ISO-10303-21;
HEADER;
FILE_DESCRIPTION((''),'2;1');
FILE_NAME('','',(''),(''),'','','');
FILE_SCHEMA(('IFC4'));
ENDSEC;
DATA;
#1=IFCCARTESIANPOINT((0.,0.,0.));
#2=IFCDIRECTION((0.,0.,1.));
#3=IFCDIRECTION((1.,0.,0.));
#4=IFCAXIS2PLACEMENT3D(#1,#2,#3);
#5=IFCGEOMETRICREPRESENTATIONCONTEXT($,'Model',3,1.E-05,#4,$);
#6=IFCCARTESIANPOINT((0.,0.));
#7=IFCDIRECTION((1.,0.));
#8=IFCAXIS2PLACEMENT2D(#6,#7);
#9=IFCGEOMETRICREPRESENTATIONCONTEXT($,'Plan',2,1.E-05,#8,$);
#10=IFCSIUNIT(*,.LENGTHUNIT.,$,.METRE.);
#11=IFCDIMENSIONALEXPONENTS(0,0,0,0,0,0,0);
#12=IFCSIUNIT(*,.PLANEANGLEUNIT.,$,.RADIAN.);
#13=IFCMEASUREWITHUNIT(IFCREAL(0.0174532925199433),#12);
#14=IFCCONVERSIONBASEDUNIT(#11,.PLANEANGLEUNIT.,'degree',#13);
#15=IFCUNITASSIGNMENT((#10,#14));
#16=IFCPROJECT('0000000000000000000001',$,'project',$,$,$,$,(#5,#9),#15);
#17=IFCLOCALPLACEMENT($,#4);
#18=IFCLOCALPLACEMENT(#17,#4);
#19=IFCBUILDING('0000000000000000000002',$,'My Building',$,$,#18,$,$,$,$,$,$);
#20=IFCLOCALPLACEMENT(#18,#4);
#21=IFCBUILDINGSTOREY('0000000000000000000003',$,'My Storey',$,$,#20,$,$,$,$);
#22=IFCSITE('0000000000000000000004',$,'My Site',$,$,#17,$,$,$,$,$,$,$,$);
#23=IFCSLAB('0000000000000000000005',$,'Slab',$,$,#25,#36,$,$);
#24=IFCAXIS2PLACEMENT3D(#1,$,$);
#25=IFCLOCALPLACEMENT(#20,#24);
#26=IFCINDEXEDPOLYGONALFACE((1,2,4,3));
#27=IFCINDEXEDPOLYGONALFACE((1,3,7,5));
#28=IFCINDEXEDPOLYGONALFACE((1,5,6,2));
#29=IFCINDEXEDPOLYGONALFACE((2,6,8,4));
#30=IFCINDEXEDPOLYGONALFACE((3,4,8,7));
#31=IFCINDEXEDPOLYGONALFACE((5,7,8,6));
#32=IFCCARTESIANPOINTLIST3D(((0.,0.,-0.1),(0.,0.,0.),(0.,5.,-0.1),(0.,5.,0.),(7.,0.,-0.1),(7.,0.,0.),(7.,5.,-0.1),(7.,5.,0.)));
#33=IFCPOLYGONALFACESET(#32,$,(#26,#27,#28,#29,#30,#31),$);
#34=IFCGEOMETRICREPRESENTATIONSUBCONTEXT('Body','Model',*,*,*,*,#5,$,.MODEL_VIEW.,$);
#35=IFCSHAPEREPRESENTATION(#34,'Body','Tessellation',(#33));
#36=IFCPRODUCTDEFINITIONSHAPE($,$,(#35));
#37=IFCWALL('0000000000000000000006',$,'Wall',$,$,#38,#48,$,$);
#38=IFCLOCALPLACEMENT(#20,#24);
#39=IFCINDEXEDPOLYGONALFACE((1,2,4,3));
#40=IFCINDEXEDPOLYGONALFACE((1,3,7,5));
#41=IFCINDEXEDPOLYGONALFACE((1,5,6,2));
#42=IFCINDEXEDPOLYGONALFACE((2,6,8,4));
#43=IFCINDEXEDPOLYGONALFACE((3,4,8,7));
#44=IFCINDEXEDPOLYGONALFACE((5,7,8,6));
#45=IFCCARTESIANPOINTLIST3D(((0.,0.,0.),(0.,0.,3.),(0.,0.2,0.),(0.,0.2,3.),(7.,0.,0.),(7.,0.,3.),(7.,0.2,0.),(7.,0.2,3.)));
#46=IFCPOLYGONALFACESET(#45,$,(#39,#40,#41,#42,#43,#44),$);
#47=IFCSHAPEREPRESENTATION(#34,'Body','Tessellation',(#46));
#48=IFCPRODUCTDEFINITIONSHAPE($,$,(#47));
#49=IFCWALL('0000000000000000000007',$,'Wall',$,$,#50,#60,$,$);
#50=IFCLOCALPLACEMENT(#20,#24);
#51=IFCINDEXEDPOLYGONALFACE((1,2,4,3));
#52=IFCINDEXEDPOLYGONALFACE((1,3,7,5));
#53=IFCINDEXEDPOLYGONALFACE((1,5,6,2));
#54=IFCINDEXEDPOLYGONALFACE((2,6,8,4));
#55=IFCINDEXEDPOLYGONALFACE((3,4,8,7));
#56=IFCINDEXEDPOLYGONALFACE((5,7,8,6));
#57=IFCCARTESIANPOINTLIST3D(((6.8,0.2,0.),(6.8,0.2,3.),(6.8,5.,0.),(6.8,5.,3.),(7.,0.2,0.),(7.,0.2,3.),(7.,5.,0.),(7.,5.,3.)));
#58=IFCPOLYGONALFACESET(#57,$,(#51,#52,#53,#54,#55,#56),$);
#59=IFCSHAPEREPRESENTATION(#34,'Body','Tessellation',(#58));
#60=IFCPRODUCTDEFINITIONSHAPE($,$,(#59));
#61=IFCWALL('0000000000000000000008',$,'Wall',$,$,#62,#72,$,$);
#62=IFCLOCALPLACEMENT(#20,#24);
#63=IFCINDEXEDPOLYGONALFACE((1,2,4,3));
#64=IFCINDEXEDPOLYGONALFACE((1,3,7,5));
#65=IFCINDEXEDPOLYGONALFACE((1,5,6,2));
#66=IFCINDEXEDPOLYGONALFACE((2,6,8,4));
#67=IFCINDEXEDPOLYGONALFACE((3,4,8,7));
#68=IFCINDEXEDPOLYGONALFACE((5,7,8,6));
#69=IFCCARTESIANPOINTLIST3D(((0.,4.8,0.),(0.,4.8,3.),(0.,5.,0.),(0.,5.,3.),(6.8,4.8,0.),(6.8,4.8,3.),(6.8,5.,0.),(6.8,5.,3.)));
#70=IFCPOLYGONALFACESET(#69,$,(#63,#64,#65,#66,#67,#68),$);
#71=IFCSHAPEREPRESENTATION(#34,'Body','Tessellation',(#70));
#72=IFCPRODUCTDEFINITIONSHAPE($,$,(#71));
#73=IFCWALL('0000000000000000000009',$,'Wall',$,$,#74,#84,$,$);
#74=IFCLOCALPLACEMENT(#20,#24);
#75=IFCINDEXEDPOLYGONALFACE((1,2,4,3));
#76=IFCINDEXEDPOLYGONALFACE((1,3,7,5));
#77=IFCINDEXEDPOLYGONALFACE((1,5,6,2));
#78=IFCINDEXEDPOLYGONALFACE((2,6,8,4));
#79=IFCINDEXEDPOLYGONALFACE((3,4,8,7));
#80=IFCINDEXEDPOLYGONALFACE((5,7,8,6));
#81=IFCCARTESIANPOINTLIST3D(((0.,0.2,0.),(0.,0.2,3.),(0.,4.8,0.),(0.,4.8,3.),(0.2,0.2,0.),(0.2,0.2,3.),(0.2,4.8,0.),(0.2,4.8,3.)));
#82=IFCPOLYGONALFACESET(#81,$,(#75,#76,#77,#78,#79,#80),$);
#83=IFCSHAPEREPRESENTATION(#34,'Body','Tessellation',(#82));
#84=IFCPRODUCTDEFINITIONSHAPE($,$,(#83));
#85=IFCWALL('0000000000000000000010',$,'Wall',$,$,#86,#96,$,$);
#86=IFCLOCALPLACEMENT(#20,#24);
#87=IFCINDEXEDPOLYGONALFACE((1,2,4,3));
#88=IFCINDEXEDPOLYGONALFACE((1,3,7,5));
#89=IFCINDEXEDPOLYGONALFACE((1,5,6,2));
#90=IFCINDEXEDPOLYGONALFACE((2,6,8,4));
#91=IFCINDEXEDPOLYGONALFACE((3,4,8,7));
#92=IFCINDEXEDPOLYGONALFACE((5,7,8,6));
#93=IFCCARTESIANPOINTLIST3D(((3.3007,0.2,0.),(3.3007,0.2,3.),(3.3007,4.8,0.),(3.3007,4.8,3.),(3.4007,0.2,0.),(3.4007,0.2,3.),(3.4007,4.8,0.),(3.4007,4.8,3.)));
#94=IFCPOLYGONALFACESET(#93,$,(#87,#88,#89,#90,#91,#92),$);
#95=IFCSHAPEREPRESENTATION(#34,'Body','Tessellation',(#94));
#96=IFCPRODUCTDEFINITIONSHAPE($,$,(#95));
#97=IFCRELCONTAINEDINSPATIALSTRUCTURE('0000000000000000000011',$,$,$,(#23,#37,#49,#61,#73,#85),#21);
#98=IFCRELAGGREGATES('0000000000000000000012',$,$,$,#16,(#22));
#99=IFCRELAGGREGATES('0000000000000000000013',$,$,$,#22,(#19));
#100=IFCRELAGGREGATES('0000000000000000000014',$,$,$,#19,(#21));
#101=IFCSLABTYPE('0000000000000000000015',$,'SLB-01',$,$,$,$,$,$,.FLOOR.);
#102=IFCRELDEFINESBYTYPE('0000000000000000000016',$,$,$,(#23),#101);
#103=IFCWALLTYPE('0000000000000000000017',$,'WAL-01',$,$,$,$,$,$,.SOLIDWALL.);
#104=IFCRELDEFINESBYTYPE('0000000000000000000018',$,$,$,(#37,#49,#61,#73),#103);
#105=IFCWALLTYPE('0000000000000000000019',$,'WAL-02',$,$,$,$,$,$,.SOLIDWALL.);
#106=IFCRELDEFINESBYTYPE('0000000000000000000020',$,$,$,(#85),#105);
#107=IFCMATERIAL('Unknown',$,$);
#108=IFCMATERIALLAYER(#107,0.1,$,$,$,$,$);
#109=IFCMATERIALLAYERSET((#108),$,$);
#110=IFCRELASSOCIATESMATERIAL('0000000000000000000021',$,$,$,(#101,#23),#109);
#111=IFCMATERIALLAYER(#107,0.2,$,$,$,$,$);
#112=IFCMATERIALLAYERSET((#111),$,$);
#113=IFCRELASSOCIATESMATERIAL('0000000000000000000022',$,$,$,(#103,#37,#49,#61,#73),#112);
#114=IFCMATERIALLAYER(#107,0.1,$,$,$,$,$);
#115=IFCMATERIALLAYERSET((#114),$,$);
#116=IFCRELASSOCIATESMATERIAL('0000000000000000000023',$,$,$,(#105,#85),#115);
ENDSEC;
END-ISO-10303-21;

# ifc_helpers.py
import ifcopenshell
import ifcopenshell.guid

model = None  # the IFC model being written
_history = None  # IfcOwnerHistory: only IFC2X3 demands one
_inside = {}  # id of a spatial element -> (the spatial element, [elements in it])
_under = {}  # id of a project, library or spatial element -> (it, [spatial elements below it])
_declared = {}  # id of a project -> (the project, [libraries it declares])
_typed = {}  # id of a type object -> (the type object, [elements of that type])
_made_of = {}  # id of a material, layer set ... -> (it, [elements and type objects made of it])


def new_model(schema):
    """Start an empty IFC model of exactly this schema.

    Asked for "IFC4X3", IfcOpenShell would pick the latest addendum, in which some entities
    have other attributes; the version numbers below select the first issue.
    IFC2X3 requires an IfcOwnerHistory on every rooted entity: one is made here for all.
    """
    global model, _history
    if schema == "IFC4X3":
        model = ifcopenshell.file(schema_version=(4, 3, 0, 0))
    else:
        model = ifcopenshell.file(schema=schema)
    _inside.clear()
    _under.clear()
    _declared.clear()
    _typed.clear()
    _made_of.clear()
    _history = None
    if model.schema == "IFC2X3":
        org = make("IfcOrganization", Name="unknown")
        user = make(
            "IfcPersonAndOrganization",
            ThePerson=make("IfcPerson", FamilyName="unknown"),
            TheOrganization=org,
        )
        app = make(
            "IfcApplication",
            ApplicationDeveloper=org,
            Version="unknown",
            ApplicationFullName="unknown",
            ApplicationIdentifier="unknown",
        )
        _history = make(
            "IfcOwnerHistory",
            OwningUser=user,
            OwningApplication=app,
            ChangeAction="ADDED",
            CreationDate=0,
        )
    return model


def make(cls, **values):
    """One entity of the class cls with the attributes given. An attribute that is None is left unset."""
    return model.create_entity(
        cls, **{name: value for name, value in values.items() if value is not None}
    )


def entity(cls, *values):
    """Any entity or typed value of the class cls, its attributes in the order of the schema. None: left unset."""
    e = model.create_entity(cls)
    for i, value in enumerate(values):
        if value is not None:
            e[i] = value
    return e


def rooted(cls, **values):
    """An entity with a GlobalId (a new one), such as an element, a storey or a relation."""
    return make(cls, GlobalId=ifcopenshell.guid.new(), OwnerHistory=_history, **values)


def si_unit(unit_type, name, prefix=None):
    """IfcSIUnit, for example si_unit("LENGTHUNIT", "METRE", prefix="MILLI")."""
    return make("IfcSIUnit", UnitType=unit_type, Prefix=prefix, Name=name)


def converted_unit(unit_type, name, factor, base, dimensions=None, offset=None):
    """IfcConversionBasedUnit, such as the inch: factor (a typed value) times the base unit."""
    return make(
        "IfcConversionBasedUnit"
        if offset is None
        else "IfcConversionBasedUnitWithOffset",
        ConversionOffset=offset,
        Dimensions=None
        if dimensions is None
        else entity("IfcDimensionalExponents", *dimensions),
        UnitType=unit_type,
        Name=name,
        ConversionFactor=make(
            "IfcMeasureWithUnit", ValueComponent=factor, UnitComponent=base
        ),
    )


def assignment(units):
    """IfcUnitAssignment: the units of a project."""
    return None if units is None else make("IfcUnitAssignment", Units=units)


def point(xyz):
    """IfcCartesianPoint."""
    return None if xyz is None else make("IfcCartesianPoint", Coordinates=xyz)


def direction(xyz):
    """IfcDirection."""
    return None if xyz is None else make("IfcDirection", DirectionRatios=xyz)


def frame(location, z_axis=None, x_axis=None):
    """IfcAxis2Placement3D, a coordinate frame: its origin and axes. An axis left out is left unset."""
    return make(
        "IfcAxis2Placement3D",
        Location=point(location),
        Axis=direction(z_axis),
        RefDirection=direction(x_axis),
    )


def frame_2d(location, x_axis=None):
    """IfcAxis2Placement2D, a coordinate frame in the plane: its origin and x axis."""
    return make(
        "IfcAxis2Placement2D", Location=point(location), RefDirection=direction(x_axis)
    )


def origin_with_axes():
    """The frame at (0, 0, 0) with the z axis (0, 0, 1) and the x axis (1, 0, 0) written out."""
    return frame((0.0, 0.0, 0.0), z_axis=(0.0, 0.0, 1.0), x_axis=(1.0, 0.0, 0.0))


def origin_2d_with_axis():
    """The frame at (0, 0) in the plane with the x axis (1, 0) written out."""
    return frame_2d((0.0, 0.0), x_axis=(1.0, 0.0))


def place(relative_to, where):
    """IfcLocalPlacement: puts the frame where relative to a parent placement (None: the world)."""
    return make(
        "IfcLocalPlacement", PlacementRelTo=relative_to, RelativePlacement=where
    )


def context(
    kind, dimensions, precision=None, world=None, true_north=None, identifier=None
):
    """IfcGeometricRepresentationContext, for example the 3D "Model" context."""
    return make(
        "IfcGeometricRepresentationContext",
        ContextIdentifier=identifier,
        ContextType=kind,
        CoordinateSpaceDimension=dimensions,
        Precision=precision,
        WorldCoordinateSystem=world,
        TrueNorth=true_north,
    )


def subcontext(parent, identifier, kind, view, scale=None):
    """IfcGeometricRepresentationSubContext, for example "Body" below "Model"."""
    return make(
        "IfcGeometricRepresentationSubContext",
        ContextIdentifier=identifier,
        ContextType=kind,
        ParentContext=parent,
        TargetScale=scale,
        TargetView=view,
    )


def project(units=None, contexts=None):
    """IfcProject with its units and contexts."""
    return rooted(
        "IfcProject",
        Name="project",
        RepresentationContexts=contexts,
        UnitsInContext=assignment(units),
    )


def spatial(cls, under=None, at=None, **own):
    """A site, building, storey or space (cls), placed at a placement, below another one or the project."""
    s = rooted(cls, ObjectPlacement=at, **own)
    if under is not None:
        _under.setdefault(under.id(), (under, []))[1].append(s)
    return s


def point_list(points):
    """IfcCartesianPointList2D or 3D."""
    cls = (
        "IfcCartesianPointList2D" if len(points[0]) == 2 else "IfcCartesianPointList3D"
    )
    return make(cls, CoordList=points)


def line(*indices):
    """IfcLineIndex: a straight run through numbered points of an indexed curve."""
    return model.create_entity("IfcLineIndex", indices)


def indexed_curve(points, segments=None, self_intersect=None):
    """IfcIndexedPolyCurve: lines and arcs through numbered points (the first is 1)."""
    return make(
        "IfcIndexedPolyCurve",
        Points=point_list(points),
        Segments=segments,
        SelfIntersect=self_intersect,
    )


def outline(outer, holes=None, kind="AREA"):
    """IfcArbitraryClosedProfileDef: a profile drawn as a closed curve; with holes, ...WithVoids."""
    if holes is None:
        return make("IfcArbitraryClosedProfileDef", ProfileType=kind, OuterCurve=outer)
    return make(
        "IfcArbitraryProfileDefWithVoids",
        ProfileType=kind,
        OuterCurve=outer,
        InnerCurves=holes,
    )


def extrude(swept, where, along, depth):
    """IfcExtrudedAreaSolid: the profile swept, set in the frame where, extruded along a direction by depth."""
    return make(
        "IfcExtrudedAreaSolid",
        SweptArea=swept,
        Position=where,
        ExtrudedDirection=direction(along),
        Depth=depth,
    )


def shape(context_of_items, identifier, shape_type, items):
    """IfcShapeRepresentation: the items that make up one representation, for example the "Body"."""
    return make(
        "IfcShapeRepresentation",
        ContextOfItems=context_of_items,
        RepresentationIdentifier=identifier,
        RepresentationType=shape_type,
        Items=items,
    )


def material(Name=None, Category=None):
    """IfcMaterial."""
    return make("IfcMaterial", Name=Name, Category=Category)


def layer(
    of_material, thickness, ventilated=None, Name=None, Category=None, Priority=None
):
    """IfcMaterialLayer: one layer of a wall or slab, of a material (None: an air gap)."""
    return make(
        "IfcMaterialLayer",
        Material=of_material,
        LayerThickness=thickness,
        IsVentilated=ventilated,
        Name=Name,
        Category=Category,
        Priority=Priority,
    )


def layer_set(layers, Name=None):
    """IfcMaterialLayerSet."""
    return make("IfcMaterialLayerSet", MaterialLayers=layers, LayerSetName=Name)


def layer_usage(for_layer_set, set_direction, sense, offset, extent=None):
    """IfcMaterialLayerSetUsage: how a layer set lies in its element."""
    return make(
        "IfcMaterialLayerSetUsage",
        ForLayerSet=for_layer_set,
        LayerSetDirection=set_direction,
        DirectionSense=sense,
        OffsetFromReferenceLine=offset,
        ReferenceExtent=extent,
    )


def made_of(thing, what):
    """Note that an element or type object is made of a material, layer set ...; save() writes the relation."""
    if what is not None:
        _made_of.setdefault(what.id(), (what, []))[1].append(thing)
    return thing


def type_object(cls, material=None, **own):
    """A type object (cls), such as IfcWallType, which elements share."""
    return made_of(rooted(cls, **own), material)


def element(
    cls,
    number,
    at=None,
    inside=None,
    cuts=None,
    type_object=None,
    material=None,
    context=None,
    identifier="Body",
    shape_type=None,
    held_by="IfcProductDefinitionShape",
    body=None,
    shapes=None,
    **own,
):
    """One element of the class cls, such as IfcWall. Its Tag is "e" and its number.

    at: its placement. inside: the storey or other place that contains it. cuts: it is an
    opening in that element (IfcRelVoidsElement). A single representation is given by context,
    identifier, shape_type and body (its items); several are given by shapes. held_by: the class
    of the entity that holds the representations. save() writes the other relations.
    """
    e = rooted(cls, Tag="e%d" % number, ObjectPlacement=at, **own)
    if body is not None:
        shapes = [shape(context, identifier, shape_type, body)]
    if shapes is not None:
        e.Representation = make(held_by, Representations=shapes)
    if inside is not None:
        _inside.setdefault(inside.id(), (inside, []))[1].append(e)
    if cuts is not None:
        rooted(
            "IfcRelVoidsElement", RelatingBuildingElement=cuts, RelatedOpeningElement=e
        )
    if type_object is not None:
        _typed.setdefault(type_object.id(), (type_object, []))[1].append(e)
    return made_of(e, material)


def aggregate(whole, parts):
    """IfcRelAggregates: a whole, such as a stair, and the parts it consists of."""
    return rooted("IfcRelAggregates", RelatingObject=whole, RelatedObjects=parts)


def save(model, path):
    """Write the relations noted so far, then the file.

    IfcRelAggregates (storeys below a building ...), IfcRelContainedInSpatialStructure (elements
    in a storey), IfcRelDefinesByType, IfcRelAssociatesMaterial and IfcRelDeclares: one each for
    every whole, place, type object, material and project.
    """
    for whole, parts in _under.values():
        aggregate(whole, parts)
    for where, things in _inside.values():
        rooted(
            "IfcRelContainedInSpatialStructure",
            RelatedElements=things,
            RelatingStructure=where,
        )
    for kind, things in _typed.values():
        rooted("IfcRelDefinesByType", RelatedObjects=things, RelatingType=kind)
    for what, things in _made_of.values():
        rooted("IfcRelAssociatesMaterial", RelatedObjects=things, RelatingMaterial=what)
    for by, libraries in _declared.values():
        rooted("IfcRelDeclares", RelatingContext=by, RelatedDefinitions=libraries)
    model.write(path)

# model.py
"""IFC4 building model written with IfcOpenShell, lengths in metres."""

from ifc_helpers import new_model, entity, si_unit, converted_unit, frame, origin_with_axes, origin_2d_with_axis, place, context, subcontext, project, spatial, line, indexed_curve, outline, extrude, material, layer, layer_set, layer_usage, type_object, element, save


model = new_model("IFC4")

# Units and contexts
model_context = context("Model", 3, precision=1e-05, world=origin_with_axes())
plan_context = context("Plan", 2, precision=1e-05, world=origin_2d_with_axis())
body_context = subcontext(model_context, "Body", "Model", "MODEL_VIEW")
ifc_project = project(units=[si_unit("LENGTHUNIT", "METRE"), converted_unit("PLANEANGLEUNIT", "degree", entity("IfcReal", 0.0174532925199433), si_unit("PLANEANGLEUNIT", "RADIAN"), dimensions=[0, 0, 0, 0, 0, 0, 0])], contexts=[model_context, plan_context])

# Site, building, storey
site_placement = place(None, origin_with_axes())
site = spatial("IfcSite", under=ifc_project, at=site_placement, Name="My Site")
building_placement = place(site_placement, origin_with_axes())
building = spatial("IfcBuilding", under=site, at=building_placement, Name="My Building")
storey_placement = place(building_placement, origin_with_axes())
storey = spatial("IfcBuildingStorey", under=building, at=storey_placement, Name="My Storey")

# Slab
ifc_material = material(Name="Unknown")
ifc_layer_1 = layer(ifc_material, 0.1)
ifc_layer_set_1 = layer_set([ifc_layer_1])
ifc_layer_usage_1 = layer_usage(ifc_layer_set_1, "AXIS3", "POSITIVE", 0.0)
slab_type = type_object("IfcSlabType", Name="SLB-01", PredefinedType="FLOOR", material=ifc_layer_set_1)
slab_placement = place(storey_placement, frame((0.0, 0.0, -0.1), z_axis=(0.0, 0.0, 1.0), x_axis=(1.0, 0.0, 0.0)))
element("IfcSlab", 1, at=slab_placement, inside=storey, type_object=slab_type, material=ifc_layer_usage_1, Name="Slab", context=body_context, shape_type="SweptSolid", body=[
    extrude(outline(indexed_curve([(0.0, 0.0), (7.0, 0.0), (7.0, 5.0), (0.0, 5.0)], segments=[line(3, 2), line(2, 1), line(1, 4), line(4, 3)], self_intersect=False)), None, (0.0, 0.0, 1.0), 0.1),
])

# Walls
ifc_layer_2 = layer(ifc_material, 0.2)
ifc_layer_set_2 = layer_set([ifc_layer_2])
ifc_layer_usage_2 = layer_usage(ifc_layer_set_2, "AXIS2", "POSITIVE", 0.0)
wall_type_1 = type_object("IfcWallType", Name="WAL-01", PredefinedType="SOLIDWALL", material=ifc_layer_set_2)
wall_1_placement = place(storey_placement, origin_with_axes())
element("IfcWall", 2, at=wall_1_placement, inside=storey, type_object=wall_type_1, material=ifc_layer_usage_2, Name="Wall", context=body_context, shape_type="SweptSolid", body=[
    extrude(outline(indexed_curve([(0.0, 0.0), (0.0, 0.2), (7.0, 0.2), (7.0, 0.0), (0.0, 0.0)], self_intersect=False)), origin_with_axes(), (0.0, 0.0, 1.0), 3.0),
])
ifc_layer_usage_3 = layer_usage(ifc_layer_set_2, "AXIS2", "POSITIVE", 0.0)
wall_2_placement = place(storey_placement, frame((7.0, 0.2, 0.0), z_axis=(0.0, 0.0, 1.0), x_axis=(0.0, 1.0, 0.0)))
element("IfcWall", 3, at=wall_2_placement, inside=storey, type_object=wall_type_1, material=ifc_layer_usage_3, Name="Wall", context=body_context, shape_type="SweptSolid", body=[
    extrude(outline(indexed_curve([(0.0, 0.0), (0.0, 0.2), (4.8, 0.2), (4.8, 0.0), (0.0, 0.0)], self_intersect=False)), origin_with_axes(), (0.0, 0.0, 1.0), 3.0),
])
ifc_layer_usage_4 = layer_usage(ifc_layer_set_2, "AXIS2", "POSITIVE", 0.0)
wall_3_placement = place(storey_placement, frame((6.8, 5.0, 0.0), z_axis=(0.0, 0.0, 1.0), x_axis=(-1.0, 0.0, 0.0)))
element("IfcWall", 4, at=wall_3_placement, inside=storey, type_object=wall_type_1, material=ifc_layer_usage_4, Name="Wall", context=body_context, shape_type="SweptSolid", body=[
    extrude(outline(indexed_curve([(0.0, 0.0), (0.0, 0.2), (6.8, 0.2), (6.8, 0.0), (0.0, 0.0)], self_intersect=False)), origin_with_axes(), (0.0, 0.0, 1.0), 3.0),
])
ifc_layer_usage_5 = layer_usage(ifc_layer_set_2, "AXIS2", "POSITIVE", 0.0)
wall_4_placement = place(storey_placement, frame((0.0, 4.8, 0.0), z_axis=(0.0, 0.0, 1.0), x_axis=(0.0, -1.0, 0.0)))
element("IfcWall", 5, at=wall_4_placement, inside=storey, type_object=wall_type_1, material=ifc_layer_usage_5, Name="Wall", context=body_context, shape_type="SweptSolid", body=[
    extrude(outline(indexed_curve([(0.0, 0.0), (0.0, 0.2), (4.6, 0.2), (4.6, 0.0), (0.0, 0.0)], self_intersect=False)), origin_with_axes(), (0.0, 0.0, 1.0), 3.0),
])
ifc_layer_3 = layer(ifc_material, 0.1)
ifc_layer_set_3 = layer_set([ifc_layer_3])
ifc_layer_usage_6 = layer_usage(ifc_layer_set_3, "AXIS2", "POSITIVE", 0.0)
wall_type_2 = type_object("IfcWallType", Name="WAL-02", PredefinedType="SOLIDWALL", material=ifc_layer_set_3)
wall_5_placement = place(storey_placement, frame((3.3007, 4.8, 0.0), z_axis=(0.0, 0.0, 1.0), x_axis=(-0.000001, -1.0, 0.0)))
element("IfcWall", 6, at=wall_5_placement, inside=storey, type_object=wall_type_2, material=ifc_layer_usage_6, Name="Wall", context=body_context, shape_type="SweptSolid", body=[
    extrude(outline(indexed_curve([(0.0, 0.0), (0.0, 0.1), (4.6, 0.1), (4.6, 0.0), (0.0, 0.0)], self_intersect=False)), origin_with_axes(), (0.0, 0.0, 1.0), 3.0),
])

save(model, "model.ifc")
